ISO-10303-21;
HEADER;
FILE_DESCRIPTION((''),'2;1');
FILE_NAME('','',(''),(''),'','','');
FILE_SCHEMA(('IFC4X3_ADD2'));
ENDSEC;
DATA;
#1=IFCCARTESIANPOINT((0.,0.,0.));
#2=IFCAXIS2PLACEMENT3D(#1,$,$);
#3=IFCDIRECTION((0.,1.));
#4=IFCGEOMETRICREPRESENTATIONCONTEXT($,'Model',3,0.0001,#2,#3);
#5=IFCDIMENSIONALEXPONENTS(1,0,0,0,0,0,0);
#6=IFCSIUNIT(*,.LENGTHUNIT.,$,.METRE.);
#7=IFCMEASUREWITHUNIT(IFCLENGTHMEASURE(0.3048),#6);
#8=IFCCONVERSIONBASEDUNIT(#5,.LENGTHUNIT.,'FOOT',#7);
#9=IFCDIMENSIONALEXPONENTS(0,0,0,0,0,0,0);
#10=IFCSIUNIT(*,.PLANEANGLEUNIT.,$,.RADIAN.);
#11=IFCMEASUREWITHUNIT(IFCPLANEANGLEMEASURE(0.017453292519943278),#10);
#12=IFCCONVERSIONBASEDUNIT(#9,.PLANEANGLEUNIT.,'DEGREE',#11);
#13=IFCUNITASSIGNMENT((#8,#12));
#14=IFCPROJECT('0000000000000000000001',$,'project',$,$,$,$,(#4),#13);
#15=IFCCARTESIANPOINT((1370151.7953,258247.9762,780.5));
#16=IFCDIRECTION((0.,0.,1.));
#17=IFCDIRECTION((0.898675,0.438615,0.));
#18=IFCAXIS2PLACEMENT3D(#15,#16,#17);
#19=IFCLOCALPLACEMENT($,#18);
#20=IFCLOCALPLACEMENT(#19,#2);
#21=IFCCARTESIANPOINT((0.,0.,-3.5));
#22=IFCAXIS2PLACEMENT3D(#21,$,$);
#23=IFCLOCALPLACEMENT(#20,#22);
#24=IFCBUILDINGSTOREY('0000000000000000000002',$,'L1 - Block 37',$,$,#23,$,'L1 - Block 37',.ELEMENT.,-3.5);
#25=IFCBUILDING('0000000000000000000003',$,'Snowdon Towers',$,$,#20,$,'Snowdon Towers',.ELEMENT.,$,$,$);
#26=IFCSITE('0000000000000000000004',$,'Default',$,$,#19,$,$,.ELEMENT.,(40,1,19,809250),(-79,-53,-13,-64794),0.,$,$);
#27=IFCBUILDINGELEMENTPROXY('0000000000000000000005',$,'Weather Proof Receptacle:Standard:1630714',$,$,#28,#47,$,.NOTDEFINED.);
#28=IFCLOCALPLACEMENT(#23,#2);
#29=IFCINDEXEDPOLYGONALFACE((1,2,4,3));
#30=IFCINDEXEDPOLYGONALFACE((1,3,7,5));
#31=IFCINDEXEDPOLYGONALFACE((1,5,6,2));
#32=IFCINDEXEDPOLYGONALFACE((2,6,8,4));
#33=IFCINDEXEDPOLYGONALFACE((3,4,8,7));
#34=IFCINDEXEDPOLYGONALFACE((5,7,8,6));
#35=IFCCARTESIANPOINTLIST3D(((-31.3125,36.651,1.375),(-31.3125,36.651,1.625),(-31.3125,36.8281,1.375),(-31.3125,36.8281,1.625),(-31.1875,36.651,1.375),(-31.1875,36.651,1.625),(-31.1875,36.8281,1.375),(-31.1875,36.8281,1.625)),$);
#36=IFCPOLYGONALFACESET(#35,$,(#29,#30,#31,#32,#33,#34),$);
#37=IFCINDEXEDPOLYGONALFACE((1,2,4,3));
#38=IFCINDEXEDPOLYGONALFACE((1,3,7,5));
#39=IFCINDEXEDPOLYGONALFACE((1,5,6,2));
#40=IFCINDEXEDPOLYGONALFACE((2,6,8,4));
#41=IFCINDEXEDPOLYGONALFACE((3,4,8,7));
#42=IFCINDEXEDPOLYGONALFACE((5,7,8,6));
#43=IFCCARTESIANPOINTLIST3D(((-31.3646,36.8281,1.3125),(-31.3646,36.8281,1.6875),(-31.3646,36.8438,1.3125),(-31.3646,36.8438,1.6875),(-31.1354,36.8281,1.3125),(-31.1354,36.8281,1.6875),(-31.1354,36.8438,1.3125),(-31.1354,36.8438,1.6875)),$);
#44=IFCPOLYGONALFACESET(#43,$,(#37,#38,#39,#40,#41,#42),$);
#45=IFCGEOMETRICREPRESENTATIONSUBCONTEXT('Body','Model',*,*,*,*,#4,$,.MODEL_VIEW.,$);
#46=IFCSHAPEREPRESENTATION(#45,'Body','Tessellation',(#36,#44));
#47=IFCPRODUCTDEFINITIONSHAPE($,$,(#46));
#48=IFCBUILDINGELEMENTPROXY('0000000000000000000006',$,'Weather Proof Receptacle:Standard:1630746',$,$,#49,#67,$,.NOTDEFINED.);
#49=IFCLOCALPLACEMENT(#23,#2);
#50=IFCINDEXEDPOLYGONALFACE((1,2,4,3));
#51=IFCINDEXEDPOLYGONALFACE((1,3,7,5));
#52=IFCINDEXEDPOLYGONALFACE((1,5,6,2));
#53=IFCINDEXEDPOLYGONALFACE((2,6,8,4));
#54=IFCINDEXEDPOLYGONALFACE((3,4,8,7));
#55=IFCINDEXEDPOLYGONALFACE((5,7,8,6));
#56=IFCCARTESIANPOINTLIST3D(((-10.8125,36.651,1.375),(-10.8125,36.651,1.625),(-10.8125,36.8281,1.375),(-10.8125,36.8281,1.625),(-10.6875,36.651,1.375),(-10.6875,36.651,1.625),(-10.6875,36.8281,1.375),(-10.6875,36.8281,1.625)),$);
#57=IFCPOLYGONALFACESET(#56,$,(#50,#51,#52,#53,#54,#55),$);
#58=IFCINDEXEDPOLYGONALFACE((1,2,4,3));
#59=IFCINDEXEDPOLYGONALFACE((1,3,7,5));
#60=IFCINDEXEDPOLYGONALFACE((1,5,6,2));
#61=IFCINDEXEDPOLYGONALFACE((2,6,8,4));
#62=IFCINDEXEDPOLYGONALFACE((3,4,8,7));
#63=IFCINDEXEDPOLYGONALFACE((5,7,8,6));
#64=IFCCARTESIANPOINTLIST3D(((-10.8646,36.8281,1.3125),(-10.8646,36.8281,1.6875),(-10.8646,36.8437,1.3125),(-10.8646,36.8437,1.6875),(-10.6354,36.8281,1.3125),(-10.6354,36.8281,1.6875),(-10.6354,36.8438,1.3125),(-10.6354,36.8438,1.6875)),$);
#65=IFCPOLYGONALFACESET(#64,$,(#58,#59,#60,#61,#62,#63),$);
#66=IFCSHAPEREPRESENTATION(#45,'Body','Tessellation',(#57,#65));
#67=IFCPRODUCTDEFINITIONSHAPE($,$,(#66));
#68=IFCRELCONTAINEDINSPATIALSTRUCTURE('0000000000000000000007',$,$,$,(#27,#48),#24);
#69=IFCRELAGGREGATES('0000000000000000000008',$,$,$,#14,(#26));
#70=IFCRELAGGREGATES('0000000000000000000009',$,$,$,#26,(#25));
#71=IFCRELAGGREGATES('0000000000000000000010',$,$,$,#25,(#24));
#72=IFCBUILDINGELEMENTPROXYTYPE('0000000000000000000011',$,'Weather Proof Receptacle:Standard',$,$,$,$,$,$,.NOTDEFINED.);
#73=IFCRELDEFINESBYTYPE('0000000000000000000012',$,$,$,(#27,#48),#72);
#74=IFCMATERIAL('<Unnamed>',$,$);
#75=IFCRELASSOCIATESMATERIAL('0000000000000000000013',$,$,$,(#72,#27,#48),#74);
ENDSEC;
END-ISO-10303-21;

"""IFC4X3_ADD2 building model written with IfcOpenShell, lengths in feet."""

from ifc_helpers import new_model, entity, si_unit, converted_unit, direction, frame, frame_2d, origin, origin_2d_with_axis, place, context, subcontext, project, spatial, rectangle, extrude, source, transform, mapped, material, type_object, type_shapes, element, save


model = new_model("IFC4X3_ADD2")

# Units and contexts
model_context = context("Model", 3, precision=0.0001, world=origin(), true_north=direction((0.0, 1.0)))
body_context = subcontext(model_context, "Body", "Model", "MODEL_VIEW")
ifc_project = project(units=[converted_unit("LENGTHUNIT", "FOOT", entity("IfcLengthMeasure", 0.3048), si_unit("LENGTHUNIT", "METRE"), dimensions=[1, 0, 0, 0, 0, 0, 0]), converted_unit("PLANEANGLEUNIT", "DEGREE", entity("IfcPlaneAngleMeasure", 0.017453292519943278), si_unit("PLANEANGLEUNIT", "RADIAN"), dimensions=[0, 0, 0, 0, 0, 0, 0])], contexts=[model_context])

# Site, building, storey
site_placement = place(None, frame((1370151.7953, 258247.9762, 780.5), z_axis=(0.0, 0.0, 1.0), x_axis=(0.898675, 0.438615, 0.0)))
site = spatial("IfcSite", under=ifc_project, at=site_placement, Name="Default", CompositionType="ELEMENT", RefLatitude=(40, 1, 19, 809250), RefLongitude=(-79, -53, -13, -64794), RefElevation=0.0)
building_placement = place(site_placement, origin())
building = spatial("IfcBuilding", under=site, at=building_placement, Name="Snowdon Towers", LongName="Snowdon Towers", CompositionType="ELEMENT")
storey_placement = place(building_placement, frame((0.0, 0.0, -3.5)))
storey = spatial("IfcBuildingStorey", under=building, at=storey_placement, Name="L1 - Block 37", LongName="L1 - Block 37", CompositionType="ELEMENT", Elevation=-3.5)

# Building element proxies
ifc_material = material(Name="<Unnamed>")
building_element_proxy_type = type_object("IfcBuildingElementProxyType", Name="Weather Proof Receptacle:Standard", PredefinedType="NOTDEFINED", material=ifc_material)
shared_shape = source(origin(), body_context, "Body", "SweptSolid", [
    extrude(rectangle(XDim=0.125, YDim=0.25, at=origin_2d_with_axis()), frame((0.0, 0.0, -0.1771), z_axis=(0.0, 0.0, 1.0), x_axis=(-1.0, 0.0, 0.0)), (0.0, 0.0, 1.0), 0.1771),
    extrude(rectangle(XDim=0.2292, YDim=0.375, at=frame_2d((0.0, 0.0), x_axis=(1.0, 0.0))), frame((0.0, 0.0, 0.0), z_axis=(0.0, 0.0, 1.0), x_axis=(-1.0, 0.0, 0.0)), (0.0, 0.0, 1.0), 0.0156),
])
type_shapes(building_element_proxy_type, [shared_shape])
for number, where, z_axis, x_axis, name in (
    (1, (-31.25, 36.8281, 1.5), (0.0, 1.0, 0.0), (-1.0, 0.0, 0.0), "Weather Proof Receptacle:Standard:1630714"),
    (2, (-10.75, 36.8281, 1.5), (0.0, 1.0, 0.0), (-1.0, 0.0, 0.0), "Weather Proof Receptacle:Standard:1630746"),
):
    element("IfcBuildingElementProxy", number, at=place(storey_placement, frame(where, z_axis=z_axis, x_axis=x_axis)), inside=storey, type_object=building_element_proxy_type, material=ifc_material, Name=name, PredefinedType="NOTDEFINED", context=body_context, shape_type="MappedRepresentation", body=[
        mapped(shared_shape, transform((0.0, 0.0, 0.0), scale=1.0)),
    ])

save(model, "model.ifc")
